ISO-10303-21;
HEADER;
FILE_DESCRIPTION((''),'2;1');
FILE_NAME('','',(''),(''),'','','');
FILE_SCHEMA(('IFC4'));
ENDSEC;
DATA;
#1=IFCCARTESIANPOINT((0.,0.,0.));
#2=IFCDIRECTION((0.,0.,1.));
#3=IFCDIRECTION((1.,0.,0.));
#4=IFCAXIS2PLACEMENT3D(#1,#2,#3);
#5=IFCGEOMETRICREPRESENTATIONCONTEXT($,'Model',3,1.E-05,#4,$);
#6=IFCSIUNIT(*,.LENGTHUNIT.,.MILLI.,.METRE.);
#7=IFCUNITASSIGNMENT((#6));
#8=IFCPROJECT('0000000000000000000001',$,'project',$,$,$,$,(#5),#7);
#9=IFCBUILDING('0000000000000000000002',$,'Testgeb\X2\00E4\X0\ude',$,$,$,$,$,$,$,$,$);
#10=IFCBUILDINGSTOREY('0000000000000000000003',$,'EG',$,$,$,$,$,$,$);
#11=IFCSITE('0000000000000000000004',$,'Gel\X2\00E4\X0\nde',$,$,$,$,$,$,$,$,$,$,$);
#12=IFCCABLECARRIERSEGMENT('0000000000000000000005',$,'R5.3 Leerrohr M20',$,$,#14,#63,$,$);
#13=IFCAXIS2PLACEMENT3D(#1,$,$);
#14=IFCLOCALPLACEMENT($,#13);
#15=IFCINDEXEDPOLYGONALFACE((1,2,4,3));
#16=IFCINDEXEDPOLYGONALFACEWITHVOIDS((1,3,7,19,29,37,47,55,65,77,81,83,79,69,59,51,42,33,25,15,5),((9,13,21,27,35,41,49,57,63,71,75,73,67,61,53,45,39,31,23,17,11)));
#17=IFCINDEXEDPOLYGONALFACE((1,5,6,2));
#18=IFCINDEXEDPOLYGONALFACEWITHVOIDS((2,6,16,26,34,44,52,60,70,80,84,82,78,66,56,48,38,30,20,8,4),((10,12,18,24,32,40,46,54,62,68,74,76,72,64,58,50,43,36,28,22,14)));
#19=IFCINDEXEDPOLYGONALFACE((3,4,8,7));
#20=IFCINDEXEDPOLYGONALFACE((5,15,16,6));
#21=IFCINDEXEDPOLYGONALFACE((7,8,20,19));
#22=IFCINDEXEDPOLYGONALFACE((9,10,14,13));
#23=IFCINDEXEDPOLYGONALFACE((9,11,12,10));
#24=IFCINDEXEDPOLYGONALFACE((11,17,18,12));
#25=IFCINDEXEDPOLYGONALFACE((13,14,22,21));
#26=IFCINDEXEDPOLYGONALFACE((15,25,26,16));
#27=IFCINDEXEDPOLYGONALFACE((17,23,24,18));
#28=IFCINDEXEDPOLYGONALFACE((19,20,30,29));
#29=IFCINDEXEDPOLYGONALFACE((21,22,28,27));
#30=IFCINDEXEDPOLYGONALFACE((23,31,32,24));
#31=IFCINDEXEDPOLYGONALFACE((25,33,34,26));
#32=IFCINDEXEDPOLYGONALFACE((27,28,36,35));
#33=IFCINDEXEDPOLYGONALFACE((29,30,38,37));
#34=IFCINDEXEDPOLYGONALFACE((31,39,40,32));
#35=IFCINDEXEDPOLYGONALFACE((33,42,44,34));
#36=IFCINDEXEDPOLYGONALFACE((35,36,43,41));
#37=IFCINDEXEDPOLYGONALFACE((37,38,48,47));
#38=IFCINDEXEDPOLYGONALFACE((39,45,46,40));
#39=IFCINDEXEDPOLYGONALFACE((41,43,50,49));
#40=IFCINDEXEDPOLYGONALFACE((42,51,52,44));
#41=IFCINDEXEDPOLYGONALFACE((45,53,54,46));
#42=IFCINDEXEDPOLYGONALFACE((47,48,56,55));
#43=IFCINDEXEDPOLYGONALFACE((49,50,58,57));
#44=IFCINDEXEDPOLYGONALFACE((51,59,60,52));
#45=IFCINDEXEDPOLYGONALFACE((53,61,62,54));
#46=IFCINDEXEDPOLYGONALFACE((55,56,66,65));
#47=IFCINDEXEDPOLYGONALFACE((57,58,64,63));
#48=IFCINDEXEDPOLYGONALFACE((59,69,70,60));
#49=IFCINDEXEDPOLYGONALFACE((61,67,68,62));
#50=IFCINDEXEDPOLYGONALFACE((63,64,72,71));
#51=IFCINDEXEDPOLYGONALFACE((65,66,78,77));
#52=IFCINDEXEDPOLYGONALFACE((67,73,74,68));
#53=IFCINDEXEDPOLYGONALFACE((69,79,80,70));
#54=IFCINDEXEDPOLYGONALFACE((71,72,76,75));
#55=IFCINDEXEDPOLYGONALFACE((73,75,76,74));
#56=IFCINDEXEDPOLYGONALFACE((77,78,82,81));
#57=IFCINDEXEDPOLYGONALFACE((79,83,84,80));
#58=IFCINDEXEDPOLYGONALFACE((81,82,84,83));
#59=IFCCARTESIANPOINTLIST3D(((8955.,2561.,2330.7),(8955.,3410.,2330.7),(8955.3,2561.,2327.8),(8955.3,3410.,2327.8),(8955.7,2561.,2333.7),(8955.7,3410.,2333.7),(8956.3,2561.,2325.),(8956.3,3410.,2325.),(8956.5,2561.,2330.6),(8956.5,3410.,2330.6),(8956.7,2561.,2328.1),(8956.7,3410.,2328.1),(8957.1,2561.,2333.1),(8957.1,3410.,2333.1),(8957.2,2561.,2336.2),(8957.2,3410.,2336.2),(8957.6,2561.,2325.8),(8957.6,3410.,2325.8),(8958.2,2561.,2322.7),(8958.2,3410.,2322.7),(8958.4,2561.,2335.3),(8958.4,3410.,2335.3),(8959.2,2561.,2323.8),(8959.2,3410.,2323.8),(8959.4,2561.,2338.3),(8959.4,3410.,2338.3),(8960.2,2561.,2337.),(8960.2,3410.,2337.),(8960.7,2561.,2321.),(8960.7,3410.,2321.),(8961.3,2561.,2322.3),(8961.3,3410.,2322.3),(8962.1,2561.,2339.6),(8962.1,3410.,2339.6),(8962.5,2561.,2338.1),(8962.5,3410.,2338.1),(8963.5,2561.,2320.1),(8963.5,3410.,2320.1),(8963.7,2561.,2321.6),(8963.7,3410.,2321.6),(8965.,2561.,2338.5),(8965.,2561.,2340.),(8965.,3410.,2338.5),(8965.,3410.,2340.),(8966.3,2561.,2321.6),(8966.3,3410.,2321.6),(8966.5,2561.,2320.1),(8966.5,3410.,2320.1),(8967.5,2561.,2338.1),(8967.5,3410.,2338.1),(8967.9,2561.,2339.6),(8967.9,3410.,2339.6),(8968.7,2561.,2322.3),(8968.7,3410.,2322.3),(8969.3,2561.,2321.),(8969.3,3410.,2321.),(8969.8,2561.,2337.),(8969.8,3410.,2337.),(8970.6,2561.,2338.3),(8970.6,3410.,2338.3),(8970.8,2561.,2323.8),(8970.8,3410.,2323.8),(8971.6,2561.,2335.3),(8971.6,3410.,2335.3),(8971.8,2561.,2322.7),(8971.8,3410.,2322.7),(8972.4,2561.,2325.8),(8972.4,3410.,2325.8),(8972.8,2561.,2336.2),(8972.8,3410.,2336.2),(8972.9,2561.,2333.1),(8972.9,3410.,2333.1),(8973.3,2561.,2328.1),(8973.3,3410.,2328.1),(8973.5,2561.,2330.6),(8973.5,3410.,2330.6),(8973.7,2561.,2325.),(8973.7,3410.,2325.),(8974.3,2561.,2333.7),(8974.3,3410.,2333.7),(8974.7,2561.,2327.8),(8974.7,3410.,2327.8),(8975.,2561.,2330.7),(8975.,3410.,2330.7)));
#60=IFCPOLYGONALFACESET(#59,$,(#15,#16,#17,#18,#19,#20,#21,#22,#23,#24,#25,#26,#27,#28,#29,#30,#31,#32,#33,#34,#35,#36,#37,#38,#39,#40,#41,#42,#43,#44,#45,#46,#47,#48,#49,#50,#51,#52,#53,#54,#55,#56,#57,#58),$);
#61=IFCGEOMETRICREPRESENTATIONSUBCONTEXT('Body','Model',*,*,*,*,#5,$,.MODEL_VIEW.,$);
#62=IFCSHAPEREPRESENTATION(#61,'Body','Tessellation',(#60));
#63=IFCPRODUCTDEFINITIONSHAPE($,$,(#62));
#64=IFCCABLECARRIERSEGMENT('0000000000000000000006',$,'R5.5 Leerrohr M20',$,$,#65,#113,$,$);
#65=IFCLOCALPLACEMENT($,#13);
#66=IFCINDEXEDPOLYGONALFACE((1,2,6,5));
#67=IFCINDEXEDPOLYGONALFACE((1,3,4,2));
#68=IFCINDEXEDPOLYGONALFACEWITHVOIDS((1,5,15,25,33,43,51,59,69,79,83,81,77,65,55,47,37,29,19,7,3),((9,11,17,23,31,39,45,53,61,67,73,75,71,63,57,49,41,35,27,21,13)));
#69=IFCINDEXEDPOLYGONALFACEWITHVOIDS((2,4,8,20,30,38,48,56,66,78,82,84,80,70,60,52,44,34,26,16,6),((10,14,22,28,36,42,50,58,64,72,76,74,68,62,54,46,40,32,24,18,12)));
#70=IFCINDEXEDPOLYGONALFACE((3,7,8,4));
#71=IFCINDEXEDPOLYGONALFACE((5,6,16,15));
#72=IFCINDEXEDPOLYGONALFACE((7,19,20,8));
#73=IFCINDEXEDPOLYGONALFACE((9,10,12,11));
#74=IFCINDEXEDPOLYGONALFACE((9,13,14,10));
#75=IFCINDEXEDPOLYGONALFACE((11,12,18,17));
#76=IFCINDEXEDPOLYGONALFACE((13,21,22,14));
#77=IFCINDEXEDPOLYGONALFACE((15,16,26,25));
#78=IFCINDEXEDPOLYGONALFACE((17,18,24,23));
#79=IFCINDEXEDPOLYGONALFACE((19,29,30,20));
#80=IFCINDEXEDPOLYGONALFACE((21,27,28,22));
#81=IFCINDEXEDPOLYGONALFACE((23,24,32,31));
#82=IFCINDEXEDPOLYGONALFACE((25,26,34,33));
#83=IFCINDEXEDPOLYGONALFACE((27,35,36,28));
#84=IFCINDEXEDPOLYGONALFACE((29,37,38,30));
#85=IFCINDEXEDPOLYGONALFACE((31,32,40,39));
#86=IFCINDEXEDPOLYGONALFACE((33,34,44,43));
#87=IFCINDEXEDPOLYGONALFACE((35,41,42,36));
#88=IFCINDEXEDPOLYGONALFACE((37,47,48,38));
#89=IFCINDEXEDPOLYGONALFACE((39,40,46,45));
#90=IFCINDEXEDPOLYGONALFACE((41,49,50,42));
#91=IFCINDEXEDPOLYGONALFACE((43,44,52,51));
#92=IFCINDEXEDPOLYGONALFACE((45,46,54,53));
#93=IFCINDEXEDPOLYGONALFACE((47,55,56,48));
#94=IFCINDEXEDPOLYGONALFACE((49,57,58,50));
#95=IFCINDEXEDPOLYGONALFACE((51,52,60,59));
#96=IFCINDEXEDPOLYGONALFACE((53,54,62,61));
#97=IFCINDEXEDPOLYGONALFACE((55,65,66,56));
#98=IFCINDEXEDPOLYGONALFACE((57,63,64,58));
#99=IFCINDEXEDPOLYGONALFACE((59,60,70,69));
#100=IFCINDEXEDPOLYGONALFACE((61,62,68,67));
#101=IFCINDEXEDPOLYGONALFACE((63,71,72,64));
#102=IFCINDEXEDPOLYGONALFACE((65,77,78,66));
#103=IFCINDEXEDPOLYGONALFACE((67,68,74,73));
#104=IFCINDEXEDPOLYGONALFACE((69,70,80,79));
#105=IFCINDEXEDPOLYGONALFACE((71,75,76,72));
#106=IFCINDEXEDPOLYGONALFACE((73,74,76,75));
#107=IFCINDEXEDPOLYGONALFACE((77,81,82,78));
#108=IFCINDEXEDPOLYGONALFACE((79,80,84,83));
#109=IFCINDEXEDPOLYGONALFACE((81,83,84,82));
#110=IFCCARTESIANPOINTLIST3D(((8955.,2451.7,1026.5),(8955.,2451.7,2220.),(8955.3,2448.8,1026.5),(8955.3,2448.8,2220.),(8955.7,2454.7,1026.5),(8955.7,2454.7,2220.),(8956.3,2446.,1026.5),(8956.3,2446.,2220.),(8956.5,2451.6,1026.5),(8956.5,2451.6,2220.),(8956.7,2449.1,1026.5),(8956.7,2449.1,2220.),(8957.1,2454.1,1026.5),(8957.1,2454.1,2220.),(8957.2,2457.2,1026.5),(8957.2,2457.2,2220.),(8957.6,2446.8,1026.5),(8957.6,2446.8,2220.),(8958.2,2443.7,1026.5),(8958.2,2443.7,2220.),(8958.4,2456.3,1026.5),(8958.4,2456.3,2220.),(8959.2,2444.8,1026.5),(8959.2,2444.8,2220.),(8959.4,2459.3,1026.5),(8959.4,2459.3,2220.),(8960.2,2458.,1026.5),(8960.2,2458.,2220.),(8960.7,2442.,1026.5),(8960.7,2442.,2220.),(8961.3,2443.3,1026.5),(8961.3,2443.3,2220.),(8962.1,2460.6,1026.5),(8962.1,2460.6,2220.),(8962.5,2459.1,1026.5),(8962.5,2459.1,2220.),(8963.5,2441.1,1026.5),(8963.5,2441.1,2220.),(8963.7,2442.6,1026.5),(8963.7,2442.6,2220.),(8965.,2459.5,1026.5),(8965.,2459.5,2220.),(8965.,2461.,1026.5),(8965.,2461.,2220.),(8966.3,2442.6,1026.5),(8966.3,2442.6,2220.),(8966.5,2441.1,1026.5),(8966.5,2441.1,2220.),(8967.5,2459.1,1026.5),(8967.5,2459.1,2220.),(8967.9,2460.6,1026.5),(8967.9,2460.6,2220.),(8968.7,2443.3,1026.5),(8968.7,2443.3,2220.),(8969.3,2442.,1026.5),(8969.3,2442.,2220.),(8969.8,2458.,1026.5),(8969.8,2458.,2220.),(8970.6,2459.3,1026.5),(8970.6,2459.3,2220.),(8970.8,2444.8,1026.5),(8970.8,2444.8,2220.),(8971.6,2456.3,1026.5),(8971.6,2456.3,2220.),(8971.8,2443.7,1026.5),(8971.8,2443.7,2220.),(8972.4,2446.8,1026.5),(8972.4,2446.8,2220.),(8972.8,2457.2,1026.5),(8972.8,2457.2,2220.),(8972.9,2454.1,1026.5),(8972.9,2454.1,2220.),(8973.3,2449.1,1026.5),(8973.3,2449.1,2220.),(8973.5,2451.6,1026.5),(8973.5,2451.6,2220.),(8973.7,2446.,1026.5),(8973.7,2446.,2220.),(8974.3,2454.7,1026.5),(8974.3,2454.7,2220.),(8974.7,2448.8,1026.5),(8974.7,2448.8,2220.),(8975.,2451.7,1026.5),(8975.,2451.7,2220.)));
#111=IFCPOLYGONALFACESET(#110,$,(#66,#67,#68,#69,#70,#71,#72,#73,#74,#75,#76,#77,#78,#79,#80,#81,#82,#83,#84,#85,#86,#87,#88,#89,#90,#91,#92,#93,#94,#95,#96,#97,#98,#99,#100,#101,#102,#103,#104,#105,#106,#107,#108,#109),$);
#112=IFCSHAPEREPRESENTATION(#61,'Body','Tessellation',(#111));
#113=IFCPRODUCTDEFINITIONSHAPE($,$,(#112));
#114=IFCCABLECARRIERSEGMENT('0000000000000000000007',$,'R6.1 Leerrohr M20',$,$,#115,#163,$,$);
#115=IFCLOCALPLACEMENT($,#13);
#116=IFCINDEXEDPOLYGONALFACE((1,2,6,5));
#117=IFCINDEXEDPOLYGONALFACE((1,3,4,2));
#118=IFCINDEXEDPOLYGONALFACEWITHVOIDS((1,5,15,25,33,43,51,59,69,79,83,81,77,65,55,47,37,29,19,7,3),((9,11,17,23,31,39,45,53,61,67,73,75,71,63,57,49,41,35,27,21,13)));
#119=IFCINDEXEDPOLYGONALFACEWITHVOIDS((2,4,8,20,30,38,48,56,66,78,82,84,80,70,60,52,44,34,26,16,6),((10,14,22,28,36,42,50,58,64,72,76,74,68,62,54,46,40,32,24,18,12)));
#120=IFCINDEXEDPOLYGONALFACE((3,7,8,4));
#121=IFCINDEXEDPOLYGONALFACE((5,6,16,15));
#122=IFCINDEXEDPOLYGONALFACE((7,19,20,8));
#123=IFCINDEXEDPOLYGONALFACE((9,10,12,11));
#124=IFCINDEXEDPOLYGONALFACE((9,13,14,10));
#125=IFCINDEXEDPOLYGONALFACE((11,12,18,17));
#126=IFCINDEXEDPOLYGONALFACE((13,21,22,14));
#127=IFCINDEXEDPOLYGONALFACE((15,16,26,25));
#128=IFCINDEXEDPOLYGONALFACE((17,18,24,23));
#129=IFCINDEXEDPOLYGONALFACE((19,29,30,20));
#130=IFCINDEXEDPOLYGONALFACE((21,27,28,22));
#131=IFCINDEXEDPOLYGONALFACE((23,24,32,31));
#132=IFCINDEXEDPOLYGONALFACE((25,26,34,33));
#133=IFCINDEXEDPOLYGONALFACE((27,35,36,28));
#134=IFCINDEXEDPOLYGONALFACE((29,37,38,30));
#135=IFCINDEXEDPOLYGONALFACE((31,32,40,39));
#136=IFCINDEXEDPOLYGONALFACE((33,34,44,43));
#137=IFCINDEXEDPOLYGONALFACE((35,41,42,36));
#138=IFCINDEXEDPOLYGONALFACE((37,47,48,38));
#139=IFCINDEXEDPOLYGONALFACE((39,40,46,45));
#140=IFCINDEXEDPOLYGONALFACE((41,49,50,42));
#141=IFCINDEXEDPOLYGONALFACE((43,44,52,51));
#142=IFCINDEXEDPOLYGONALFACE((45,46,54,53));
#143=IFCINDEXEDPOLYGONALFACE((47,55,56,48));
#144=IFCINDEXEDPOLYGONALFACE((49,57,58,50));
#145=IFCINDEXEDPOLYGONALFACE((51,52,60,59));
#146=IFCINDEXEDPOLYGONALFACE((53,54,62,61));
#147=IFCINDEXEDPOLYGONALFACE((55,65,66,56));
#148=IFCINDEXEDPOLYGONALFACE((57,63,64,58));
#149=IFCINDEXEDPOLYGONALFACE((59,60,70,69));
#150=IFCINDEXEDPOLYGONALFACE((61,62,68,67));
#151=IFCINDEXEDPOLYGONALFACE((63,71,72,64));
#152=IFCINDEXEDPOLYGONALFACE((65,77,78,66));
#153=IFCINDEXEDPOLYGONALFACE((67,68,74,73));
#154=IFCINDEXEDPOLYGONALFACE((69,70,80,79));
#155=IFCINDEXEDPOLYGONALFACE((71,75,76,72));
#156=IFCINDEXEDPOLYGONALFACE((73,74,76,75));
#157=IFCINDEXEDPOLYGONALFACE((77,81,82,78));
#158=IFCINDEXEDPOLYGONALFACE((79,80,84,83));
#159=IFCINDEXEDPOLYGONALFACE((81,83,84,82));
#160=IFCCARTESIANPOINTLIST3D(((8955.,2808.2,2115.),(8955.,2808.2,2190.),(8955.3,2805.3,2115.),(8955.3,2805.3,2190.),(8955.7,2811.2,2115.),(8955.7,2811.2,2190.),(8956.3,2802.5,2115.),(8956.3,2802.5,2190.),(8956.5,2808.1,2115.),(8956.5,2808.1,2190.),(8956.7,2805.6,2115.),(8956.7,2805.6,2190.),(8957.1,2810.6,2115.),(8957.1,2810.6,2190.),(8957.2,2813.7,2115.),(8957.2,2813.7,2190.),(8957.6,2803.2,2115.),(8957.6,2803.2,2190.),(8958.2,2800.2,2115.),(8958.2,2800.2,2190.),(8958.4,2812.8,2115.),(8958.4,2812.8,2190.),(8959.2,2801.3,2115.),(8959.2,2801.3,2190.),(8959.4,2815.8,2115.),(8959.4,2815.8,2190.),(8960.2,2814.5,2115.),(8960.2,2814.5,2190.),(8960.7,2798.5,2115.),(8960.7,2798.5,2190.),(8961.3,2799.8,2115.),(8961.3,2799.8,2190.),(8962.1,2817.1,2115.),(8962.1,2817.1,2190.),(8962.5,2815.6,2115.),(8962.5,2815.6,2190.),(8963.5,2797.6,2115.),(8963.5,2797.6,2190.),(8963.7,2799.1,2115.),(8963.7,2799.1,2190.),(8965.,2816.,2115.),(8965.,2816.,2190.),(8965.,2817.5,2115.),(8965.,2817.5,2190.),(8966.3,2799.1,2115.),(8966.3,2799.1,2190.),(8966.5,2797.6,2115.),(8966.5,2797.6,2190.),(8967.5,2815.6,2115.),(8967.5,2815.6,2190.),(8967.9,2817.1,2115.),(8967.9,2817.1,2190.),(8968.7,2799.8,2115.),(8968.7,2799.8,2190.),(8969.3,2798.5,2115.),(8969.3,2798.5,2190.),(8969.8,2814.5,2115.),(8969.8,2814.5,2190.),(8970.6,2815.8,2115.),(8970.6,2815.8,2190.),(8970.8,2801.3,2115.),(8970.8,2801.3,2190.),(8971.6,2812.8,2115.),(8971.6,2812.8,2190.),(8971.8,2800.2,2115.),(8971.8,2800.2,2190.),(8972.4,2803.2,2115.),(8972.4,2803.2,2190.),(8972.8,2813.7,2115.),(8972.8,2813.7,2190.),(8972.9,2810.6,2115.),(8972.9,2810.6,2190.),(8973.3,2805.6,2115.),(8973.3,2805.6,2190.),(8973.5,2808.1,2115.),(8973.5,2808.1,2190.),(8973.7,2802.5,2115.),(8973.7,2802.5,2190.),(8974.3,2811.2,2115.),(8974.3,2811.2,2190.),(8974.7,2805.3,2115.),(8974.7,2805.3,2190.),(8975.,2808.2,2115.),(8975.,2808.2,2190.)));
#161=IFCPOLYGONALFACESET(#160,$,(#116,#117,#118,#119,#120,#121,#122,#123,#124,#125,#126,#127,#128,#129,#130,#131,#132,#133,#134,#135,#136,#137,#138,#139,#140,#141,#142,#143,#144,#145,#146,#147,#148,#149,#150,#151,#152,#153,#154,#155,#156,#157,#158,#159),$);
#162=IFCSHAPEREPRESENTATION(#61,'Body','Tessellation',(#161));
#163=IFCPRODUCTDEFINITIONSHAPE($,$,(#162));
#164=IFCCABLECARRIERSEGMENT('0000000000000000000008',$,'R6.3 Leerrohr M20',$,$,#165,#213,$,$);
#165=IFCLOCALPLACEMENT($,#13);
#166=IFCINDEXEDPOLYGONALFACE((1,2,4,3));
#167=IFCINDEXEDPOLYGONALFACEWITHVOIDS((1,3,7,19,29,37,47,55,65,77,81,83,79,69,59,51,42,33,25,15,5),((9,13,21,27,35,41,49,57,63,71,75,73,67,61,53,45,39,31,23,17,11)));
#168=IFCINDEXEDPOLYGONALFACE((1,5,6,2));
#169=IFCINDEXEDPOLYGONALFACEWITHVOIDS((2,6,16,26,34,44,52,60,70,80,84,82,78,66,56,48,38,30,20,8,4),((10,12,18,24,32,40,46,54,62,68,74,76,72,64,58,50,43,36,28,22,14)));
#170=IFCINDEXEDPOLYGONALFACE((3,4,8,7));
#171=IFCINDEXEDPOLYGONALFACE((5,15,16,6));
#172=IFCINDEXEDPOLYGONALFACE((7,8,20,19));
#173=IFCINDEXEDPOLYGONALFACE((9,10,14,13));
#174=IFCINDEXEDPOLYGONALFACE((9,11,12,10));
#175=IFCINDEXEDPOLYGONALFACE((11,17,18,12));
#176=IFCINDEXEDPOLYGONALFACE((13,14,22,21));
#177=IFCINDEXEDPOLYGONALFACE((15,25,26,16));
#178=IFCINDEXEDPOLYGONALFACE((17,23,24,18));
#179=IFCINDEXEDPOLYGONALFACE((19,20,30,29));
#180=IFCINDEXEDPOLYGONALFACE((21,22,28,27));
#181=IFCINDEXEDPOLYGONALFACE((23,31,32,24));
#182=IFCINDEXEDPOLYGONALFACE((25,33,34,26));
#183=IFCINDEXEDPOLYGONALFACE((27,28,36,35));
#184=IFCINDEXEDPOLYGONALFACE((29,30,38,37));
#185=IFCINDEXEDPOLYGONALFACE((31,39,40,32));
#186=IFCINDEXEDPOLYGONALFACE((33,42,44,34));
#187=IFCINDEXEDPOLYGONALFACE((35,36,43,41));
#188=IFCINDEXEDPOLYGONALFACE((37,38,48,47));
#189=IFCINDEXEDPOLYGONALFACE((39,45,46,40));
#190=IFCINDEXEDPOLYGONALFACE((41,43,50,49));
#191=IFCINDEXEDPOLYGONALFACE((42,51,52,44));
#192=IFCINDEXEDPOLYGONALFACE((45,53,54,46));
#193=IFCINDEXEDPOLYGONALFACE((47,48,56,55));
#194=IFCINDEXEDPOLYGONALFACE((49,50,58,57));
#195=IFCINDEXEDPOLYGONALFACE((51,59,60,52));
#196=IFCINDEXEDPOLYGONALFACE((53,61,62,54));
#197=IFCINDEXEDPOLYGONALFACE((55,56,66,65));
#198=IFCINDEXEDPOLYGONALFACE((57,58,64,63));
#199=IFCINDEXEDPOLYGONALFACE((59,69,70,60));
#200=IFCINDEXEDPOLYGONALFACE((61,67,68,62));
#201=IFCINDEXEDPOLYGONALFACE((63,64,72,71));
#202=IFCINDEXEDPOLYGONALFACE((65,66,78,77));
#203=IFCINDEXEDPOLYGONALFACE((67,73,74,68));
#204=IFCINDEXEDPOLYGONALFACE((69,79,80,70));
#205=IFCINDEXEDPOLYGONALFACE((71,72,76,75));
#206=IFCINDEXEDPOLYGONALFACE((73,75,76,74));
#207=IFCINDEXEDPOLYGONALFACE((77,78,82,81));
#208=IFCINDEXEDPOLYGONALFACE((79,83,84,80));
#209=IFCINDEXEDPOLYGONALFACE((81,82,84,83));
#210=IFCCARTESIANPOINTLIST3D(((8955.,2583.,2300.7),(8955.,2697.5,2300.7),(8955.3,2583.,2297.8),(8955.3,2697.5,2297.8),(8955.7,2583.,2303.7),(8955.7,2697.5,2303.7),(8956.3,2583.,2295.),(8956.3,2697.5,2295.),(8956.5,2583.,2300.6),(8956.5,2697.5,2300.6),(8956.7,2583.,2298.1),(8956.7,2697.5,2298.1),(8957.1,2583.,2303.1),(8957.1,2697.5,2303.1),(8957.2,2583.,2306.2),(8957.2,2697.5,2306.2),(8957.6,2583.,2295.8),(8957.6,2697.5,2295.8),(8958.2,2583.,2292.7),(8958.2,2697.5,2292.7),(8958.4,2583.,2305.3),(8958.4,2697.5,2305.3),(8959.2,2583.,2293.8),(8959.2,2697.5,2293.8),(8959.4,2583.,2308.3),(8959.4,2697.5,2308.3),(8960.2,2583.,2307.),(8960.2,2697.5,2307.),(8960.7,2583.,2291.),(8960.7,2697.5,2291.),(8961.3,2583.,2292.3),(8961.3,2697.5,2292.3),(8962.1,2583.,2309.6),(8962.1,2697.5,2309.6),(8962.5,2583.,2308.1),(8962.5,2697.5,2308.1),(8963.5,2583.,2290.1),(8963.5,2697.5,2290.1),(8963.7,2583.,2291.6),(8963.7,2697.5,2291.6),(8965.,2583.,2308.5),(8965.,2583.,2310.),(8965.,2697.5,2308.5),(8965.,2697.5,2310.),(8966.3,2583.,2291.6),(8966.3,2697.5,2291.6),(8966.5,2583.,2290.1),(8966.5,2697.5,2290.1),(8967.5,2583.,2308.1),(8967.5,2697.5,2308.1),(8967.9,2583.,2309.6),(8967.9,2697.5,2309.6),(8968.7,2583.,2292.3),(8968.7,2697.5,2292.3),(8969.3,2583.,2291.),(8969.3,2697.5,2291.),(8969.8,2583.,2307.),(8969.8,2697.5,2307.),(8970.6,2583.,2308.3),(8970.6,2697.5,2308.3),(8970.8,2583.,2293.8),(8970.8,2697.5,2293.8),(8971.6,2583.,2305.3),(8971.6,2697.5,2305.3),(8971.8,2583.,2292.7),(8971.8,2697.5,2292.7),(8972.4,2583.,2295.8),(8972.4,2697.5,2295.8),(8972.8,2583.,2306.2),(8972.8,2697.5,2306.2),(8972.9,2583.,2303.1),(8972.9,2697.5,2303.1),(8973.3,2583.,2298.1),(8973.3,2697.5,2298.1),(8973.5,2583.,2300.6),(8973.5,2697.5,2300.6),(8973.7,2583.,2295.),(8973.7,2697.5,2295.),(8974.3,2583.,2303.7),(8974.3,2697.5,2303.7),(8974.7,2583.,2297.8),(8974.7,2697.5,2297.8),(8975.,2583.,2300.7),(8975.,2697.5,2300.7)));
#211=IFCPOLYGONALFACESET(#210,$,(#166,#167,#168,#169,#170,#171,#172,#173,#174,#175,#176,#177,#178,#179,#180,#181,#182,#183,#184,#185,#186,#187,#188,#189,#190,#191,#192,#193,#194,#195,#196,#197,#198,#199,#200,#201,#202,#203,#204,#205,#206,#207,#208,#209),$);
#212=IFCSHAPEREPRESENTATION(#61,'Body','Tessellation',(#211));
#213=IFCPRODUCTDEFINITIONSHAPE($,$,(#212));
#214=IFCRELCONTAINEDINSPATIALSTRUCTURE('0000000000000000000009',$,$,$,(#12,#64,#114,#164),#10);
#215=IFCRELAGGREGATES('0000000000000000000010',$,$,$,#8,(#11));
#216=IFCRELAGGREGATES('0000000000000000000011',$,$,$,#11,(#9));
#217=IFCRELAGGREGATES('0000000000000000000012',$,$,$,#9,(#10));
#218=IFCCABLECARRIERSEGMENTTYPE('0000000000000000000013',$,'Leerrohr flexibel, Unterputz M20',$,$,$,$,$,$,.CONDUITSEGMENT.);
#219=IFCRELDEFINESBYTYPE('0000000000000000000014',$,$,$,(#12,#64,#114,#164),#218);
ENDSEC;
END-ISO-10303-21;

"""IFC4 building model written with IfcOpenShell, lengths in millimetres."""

from ifc_helpers import new_model, si_unit, frame, origin_with_axes, place, context, subcontext, project, spatial, hollow_circle, extrude, type_object, element, save


model = new_model("IFC4")

# Units and contexts
model_context = context("Model", 3, precision=1e-05, world=origin_with_axes())
body_context = subcontext(model_context, "Body", "Model", "MODEL_VIEW")
ifc_project = project(units=[si_unit("LENGTHUNIT", "METRE", prefix="MILLI")], contexts=[model_context])

# Site, building, storey
site = spatial("IfcSite", under=ifc_project, Name="Gelände")
building = spatial("IfcBuilding", under=site, Name="Testgebäude")
storey = spatial("IfcBuildingStorey", under=building, Name="EG")

# Cable carrier segments
cable_carrier_segment_type_1 = type_object("IfcCableCarrierSegmentType", Name="Leerrohr flexibel, Unterputz M20", PredefinedType="CONDUITSEGMENT")
cable_carrier_segment_1_placement = place(None, frame((8965.0, 3410.0, 2330.0), z_axis=(0.0, -1.0, 0.0), x_axis=(0.0, 0.0, 1.0)))
element("IfcCableCarrierSegment", 1, at=cable_carrier_segment_1_placement, inside=storey, type_object=cable_carrier_segment_type_1, Name="R5.3 Leerrohr M20", context=body_context, shape_type="SweptSolid", body=[
    extrude(hollow_circle(Radius=10.0, WallThickness=1.5), None, (0.0, 0.0, 1.0), 849.0),
])
cable_carrier_segment_2_placement = place(None, frame((8965.0, 2451.0, 2220.0), z_axis=(0.0, 0.0, -1.0), x_axis=(0.0, 1.0, 0.0)))
element("IfcCableCarrierSegment", 2, at=cable_carrier_segment_2_placement, inside=storey, type_object=cable_carrier_segment_type_1, Name="R5.5 Leerrohr M20", context=body_context, shape_type="SweptSolid", body=[
    extrude(hollow_circle(Radius=10.0, WallThickness=1.5), None, (0.0, 0.0, 1.0), 1193.5),
])
cable_carrier_segment_3_placement = place(None, frame((8965.0, 2807.5, 2115.0), z_axis=(0.0, 0.0, 1.0), x_axis=(0.0, 1.0, 0.0)))
element("IfcCableCarrierSegment", 3, at=cable_carrier_segment_3_placement, inside=storey, type_object=cable_carrier_segment_type_1, Name="R6.1 Leerrohr M20", context=body_context, shape_type="SweptSolid", body=[
    extrude(hollow_circle(Radius=10.0, WallThickness=1.5), None, (0.0, 0.0, 1.0), 75.0),
])
cable_carrier_segment_4_placement = place(None, frame((8965.0, 2697.5, 2300.0), z_axis=(0.0, -1.0, 0.0), x_axis=(0.0, 0.0, 1.0)))
element("IfcCableCarrierSegment", 4, at=cable_carrier_segment_4_placement, inside=storey, type_object=cable_carrier_segment_type_1, Name="R6.3 Leerrohr M20", context=body_context, shape_type="SweptSolid", body=[
    extrude(hollow_circle(Radius=10.0, WallThickness=1.5), None, (0.0, 0.0, 1.0), 114.5),
])

save(model, "model.ifc")
